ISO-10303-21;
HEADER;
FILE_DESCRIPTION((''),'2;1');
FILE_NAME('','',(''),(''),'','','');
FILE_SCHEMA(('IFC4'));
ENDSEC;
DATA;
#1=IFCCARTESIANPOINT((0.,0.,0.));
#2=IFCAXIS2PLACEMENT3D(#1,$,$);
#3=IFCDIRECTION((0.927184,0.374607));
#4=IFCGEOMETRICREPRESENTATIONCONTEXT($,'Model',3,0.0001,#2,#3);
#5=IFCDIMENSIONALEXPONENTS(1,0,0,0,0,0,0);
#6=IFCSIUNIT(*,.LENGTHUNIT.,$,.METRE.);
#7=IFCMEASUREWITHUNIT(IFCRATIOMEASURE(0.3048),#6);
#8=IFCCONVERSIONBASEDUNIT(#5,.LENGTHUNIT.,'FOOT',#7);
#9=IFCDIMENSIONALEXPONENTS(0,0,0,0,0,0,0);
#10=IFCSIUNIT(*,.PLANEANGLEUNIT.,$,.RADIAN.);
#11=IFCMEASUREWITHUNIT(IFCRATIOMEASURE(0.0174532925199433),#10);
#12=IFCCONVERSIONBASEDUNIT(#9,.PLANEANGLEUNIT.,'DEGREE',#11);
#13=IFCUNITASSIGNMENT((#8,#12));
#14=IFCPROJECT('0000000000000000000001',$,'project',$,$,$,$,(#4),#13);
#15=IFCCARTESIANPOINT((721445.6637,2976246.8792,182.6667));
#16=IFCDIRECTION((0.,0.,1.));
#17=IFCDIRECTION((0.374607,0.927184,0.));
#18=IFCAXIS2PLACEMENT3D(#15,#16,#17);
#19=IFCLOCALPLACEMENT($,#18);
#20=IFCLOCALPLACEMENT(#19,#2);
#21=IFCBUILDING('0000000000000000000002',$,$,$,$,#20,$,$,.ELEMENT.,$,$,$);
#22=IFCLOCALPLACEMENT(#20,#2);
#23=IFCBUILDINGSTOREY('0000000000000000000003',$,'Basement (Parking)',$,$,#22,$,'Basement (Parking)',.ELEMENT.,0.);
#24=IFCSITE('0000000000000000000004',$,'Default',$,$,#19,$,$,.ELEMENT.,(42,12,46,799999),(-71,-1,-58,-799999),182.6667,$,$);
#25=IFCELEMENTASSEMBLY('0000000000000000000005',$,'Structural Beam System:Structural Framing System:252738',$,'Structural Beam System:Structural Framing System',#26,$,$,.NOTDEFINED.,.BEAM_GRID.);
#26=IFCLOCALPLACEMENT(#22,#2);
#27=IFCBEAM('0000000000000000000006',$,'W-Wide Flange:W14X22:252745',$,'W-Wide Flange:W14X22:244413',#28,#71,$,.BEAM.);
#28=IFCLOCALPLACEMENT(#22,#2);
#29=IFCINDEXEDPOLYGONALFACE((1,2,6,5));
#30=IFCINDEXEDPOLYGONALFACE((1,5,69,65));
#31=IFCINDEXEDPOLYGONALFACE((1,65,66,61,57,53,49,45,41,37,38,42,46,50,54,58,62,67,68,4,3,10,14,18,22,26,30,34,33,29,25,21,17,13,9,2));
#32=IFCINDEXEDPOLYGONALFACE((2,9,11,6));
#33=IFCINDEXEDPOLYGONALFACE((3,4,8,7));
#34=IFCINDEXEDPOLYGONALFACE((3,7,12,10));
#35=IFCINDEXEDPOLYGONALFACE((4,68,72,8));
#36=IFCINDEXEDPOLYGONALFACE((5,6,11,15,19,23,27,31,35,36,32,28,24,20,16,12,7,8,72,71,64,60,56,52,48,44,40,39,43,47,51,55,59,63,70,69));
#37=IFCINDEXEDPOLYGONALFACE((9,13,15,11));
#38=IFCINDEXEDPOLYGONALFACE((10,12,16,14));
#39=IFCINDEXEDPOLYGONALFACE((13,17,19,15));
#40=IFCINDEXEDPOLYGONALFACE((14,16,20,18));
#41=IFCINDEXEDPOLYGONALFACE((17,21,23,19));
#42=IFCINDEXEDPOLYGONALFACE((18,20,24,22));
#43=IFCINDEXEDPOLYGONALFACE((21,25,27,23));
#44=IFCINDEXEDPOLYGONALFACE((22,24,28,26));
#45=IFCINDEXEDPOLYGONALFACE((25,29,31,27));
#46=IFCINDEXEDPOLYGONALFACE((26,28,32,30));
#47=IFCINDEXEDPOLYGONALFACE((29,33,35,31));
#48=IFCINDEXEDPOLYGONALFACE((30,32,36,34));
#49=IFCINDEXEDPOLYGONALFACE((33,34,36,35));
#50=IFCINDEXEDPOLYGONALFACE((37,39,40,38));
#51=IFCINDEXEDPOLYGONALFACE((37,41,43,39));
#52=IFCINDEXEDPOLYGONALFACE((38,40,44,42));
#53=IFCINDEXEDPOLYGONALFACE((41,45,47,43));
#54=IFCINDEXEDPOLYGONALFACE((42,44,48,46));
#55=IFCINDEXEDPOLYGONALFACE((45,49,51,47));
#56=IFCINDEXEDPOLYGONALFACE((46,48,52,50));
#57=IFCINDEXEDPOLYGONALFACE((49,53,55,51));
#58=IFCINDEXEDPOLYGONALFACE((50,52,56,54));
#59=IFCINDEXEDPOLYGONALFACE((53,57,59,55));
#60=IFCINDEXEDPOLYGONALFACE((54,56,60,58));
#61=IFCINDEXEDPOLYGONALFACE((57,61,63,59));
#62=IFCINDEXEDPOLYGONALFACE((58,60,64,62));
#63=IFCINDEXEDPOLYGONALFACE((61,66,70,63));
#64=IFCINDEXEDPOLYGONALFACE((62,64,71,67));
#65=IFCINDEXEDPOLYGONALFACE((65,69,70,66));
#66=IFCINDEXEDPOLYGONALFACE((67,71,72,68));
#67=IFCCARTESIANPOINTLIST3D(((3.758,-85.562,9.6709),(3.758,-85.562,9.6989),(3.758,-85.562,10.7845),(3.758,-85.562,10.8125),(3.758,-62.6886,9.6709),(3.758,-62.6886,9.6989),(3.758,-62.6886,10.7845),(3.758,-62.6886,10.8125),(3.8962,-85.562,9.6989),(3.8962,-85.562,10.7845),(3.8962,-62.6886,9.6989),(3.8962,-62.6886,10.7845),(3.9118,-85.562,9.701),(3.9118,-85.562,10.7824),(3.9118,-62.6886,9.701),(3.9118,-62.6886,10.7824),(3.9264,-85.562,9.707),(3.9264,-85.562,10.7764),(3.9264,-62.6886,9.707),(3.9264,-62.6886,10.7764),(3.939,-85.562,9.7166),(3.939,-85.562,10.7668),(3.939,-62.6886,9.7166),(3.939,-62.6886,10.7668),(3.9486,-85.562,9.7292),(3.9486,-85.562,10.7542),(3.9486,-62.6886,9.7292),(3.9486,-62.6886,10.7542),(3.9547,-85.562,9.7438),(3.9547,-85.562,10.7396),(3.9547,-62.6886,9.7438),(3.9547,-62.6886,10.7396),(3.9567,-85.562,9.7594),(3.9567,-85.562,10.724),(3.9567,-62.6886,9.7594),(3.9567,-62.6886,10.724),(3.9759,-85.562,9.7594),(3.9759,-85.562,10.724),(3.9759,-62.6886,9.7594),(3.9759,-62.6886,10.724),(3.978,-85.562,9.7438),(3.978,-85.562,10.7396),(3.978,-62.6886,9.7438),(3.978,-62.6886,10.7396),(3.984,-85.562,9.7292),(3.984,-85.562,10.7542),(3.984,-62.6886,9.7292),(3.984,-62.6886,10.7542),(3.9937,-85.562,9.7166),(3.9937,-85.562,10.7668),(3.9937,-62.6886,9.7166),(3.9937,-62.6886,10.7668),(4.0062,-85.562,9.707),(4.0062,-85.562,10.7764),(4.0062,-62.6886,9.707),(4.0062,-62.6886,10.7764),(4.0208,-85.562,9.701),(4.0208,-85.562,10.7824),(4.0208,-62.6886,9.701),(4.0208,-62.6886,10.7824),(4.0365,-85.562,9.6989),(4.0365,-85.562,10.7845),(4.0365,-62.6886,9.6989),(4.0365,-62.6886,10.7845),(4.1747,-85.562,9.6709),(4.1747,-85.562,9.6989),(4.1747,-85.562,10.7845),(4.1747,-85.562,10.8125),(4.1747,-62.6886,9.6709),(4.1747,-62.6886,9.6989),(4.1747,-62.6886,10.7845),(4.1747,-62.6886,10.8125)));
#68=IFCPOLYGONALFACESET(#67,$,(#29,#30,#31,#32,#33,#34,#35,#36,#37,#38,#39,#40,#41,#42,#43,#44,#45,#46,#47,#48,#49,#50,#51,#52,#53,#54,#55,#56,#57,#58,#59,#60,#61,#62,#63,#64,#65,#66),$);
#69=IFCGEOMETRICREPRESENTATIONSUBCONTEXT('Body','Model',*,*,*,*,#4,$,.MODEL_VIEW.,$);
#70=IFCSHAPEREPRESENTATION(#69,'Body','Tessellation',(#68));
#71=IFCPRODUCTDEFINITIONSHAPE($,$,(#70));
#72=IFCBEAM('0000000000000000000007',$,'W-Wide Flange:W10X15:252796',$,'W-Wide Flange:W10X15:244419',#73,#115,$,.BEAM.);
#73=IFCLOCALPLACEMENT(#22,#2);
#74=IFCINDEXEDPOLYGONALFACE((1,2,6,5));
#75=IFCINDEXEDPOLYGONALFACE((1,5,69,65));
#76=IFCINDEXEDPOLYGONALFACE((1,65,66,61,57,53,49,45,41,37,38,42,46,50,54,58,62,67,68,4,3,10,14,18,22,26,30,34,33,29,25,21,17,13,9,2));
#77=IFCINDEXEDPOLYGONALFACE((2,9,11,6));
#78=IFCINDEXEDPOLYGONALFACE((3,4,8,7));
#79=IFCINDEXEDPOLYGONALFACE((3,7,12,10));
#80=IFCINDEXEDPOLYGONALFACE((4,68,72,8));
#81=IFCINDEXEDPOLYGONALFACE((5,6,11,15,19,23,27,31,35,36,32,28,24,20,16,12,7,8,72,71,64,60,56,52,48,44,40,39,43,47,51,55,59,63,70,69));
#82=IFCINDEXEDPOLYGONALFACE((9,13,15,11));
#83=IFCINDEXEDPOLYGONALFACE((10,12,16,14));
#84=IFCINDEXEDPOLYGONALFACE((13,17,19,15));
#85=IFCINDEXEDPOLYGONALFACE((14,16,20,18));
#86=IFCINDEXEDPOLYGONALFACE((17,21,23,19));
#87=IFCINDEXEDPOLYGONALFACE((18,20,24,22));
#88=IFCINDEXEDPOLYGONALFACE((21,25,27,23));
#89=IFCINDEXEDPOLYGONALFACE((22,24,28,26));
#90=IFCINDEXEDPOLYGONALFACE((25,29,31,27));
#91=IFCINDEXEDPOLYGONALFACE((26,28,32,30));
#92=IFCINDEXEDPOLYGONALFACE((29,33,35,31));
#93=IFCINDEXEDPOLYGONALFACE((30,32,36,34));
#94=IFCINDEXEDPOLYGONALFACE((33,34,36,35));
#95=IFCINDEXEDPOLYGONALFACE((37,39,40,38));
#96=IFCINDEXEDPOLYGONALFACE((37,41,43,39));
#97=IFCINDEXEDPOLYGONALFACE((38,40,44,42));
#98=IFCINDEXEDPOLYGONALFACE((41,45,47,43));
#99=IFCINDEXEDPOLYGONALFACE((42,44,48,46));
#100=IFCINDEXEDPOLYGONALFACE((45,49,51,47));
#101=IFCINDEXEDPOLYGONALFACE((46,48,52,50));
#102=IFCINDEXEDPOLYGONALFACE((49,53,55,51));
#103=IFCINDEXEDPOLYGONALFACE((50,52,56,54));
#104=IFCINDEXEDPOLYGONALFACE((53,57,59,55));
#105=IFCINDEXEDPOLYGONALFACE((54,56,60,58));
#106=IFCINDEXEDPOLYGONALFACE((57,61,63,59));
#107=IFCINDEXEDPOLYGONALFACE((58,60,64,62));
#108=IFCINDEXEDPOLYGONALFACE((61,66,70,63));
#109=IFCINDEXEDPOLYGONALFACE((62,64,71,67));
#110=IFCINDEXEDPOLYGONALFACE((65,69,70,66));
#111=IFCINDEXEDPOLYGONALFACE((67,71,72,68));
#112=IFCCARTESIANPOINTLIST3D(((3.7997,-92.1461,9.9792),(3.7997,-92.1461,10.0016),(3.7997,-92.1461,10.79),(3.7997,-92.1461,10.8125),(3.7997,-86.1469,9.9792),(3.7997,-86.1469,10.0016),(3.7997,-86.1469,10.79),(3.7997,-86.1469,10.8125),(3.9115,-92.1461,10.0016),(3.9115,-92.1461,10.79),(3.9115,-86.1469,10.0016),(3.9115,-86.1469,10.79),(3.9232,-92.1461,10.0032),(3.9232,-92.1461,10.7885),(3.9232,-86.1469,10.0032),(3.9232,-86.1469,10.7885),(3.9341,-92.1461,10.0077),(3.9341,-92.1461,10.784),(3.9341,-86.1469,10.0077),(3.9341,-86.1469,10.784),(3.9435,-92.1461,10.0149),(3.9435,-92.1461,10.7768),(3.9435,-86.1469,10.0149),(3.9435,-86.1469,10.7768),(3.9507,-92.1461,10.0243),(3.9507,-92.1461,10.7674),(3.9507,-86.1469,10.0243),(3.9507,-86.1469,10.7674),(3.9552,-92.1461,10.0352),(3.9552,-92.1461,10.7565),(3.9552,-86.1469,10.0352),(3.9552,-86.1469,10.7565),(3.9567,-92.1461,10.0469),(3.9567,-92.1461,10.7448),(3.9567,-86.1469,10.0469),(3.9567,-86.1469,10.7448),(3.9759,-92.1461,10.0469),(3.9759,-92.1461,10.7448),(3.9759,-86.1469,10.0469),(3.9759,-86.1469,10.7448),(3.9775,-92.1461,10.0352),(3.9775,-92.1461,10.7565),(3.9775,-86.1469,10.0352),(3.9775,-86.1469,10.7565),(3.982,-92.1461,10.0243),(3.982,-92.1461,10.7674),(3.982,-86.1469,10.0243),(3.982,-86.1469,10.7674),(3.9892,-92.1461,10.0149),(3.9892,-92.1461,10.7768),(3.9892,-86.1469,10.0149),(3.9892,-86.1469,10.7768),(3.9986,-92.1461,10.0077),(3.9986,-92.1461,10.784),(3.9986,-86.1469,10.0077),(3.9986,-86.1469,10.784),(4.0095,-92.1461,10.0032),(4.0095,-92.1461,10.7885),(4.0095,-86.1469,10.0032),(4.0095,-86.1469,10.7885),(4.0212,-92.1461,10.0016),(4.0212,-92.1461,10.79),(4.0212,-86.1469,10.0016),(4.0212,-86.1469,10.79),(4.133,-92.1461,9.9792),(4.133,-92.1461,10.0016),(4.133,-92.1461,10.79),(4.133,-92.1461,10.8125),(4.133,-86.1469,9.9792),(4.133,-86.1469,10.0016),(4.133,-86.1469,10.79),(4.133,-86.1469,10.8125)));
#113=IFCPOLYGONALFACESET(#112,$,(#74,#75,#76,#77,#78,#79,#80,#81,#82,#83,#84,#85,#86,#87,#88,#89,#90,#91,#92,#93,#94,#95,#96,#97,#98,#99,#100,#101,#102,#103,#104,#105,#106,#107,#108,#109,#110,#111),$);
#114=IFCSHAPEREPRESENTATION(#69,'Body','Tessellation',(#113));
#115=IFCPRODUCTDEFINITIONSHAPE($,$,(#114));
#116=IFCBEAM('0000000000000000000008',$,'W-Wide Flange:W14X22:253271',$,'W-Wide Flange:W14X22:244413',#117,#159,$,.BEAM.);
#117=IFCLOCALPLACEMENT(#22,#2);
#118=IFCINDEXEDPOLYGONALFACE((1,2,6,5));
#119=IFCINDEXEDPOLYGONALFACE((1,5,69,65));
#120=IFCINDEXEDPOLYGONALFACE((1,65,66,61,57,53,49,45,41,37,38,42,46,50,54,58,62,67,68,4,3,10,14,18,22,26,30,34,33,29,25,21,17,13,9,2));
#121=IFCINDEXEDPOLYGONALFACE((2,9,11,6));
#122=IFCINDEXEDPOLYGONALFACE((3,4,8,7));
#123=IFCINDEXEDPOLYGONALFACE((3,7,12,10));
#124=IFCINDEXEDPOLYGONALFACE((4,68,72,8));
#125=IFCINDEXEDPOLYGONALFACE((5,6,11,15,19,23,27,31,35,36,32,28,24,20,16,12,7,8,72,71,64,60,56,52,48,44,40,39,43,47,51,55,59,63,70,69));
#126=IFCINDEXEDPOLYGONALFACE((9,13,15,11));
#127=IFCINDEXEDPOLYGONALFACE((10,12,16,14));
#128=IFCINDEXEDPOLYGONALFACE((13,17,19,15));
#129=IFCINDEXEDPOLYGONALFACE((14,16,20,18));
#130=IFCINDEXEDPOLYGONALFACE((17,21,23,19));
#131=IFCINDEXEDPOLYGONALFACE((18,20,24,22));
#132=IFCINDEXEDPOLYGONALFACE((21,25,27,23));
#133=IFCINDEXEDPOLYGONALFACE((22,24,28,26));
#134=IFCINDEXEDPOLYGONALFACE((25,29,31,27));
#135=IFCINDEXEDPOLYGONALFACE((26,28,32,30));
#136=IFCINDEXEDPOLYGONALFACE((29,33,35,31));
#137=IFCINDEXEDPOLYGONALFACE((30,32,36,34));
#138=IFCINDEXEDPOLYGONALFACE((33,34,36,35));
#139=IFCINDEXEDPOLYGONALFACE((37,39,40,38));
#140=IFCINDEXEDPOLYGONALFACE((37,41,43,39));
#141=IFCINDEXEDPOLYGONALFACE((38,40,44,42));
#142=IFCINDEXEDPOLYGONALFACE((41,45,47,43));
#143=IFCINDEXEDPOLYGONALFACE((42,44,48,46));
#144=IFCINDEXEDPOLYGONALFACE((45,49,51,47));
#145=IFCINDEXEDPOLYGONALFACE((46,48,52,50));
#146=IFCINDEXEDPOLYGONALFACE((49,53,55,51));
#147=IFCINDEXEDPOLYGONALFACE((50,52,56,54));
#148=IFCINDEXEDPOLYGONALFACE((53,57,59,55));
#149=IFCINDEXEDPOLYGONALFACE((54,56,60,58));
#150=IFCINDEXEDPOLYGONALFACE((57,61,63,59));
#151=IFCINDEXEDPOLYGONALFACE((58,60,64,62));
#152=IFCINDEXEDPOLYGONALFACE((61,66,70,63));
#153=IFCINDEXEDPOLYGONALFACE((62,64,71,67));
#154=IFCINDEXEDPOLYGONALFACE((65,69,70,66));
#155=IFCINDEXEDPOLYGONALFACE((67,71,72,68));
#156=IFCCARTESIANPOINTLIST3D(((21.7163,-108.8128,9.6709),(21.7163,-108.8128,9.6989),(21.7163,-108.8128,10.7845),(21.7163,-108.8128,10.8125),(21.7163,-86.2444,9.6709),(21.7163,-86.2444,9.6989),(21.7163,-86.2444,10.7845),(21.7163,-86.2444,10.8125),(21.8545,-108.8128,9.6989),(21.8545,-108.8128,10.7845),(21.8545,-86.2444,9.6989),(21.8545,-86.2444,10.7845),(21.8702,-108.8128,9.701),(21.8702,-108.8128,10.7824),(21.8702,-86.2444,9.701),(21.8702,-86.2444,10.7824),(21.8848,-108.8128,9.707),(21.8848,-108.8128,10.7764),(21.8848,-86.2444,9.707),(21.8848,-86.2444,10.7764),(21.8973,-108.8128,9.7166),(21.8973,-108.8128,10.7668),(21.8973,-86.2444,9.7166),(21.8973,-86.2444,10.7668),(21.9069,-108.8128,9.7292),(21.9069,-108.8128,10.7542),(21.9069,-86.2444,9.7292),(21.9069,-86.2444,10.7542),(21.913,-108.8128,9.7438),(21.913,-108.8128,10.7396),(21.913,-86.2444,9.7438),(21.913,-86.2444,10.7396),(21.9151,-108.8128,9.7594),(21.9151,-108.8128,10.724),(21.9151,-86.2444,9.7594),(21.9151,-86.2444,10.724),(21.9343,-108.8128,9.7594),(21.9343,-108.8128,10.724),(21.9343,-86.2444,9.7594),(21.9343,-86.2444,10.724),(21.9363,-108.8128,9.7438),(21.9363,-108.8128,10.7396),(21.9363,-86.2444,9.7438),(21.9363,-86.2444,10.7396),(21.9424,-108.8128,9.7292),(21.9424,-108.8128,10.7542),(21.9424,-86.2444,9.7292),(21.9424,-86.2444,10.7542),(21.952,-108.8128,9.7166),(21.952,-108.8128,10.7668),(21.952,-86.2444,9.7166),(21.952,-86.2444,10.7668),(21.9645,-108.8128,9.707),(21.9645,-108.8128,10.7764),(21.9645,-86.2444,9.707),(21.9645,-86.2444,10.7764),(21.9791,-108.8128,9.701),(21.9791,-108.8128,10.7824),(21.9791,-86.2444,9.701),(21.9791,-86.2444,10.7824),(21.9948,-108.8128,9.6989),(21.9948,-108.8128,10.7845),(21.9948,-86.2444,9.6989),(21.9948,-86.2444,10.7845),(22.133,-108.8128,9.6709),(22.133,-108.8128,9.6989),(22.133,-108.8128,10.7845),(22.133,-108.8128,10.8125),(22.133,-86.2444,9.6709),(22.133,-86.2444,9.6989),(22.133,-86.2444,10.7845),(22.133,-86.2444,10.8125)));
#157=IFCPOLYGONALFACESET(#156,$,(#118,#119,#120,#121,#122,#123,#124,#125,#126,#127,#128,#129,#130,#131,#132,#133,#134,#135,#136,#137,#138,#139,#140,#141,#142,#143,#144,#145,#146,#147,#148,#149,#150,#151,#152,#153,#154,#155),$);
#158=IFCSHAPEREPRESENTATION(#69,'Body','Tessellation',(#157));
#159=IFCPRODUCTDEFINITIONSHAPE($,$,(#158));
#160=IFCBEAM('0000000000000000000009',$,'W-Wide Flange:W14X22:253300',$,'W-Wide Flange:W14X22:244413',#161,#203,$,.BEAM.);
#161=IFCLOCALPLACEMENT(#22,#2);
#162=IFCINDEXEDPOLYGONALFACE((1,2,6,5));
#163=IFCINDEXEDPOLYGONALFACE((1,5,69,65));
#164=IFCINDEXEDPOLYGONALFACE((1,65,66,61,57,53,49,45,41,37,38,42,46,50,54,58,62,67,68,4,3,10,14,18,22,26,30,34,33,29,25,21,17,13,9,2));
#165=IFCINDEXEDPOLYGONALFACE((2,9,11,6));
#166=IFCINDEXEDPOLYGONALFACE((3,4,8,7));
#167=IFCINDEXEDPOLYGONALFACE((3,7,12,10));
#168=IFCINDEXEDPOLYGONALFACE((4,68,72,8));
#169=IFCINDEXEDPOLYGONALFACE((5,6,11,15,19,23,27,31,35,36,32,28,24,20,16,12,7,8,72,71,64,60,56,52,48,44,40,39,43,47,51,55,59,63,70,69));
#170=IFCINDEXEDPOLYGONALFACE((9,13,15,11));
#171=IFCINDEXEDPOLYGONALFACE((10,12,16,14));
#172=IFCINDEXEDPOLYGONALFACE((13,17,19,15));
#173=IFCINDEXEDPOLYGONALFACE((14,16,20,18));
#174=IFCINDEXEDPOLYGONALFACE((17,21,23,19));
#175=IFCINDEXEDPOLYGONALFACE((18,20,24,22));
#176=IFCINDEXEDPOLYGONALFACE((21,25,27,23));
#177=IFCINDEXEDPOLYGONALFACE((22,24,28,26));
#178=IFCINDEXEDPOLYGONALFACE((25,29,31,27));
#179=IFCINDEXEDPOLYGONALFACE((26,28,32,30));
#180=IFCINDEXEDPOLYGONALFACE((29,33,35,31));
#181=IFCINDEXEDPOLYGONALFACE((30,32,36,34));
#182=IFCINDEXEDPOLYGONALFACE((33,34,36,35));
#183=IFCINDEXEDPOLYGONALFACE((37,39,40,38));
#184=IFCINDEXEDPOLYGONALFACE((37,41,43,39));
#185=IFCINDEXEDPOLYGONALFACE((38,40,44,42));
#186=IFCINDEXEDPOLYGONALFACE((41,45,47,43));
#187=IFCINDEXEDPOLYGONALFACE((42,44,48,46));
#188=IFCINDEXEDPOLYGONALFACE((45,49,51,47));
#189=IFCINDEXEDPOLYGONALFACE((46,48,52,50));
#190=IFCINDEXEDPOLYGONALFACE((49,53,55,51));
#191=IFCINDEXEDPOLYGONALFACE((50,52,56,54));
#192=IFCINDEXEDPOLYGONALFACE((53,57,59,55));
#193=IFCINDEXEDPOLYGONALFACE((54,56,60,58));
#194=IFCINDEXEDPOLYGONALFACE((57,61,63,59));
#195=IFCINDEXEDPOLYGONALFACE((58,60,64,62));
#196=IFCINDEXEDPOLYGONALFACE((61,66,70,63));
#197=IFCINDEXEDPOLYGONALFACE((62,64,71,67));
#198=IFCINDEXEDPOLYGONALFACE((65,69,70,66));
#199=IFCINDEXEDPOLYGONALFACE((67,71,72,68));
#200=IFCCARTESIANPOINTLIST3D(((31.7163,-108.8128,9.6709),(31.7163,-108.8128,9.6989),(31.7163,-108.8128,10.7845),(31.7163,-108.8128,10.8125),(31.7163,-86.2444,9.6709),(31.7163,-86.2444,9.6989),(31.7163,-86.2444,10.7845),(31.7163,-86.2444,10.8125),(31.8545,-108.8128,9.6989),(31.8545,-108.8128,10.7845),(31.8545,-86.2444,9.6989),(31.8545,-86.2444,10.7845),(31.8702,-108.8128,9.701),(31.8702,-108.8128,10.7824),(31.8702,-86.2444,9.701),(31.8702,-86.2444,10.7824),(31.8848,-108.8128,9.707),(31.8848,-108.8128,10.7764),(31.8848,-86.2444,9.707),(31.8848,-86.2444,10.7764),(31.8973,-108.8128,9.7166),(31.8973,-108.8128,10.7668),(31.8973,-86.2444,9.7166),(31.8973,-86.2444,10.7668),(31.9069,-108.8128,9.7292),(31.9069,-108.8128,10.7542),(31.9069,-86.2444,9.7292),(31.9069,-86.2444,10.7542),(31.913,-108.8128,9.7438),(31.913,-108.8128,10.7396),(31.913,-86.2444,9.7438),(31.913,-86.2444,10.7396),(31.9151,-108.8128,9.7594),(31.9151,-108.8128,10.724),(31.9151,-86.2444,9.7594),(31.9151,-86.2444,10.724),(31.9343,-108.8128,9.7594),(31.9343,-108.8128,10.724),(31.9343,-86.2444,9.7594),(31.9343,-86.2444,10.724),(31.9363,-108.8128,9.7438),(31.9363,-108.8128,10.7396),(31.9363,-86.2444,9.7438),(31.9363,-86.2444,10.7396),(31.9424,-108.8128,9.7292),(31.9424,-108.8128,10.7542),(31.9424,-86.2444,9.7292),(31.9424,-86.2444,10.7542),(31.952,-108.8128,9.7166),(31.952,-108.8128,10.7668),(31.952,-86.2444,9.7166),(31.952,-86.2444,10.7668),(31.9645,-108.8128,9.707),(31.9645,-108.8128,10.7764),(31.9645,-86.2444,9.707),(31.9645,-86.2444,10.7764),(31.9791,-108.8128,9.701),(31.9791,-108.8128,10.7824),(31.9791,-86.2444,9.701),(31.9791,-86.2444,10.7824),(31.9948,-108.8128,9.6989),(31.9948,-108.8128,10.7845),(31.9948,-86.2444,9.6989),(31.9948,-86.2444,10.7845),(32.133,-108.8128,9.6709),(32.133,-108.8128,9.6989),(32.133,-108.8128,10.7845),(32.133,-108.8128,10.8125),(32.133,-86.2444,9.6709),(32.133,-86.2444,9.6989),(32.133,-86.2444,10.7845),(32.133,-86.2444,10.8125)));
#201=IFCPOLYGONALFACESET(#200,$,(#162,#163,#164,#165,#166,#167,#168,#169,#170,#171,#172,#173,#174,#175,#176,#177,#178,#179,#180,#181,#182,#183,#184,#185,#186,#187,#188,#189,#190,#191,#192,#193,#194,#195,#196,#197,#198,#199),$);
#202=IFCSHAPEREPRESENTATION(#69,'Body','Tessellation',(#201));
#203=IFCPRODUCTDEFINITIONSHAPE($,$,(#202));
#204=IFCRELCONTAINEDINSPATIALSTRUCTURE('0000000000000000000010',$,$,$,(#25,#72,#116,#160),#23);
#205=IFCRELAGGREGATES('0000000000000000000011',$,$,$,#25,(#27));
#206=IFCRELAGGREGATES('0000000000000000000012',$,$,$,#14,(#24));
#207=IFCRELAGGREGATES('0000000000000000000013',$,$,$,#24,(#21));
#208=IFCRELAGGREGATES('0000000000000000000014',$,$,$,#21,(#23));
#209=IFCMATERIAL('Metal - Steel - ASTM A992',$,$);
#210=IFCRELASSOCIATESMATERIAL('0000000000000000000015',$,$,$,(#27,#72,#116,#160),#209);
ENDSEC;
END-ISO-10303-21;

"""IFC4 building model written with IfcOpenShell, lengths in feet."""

from ifc_helpers import new_model, entity, si_unit, converted_unit, direction, frame, frame_2d, origin, place, context, subcontext, project, spatial, i_section, extrude, material, element, aggregate, save


model = new_model("IFC4")

# Units and contexts
model_context = context("Model", 3, precision=0.0001, world=origin(), true_north=direction((0.927184, 0.374607)))
body_context = subcontext(model_context, "Body", "Model", "MODEL_VIEW")
ifc_project = project(units=[converted_unit("LENGTHUNIT", "FOOT", entity("IfcRatioMeasure", 0.3048), si_unit("LENGTHUNIT", "METRE"), dimensions=[1, 0, 0, 0, 0, 0, 0]), converted_unit("PLANEANGLEUNIT", "DEGREE", entity("IfcRatioMeasure", 0.0174532925199433), si_unit("PLANEANGLEUNIT", "RADIAN"), dimensions=[0, 0, 0, 0, 0, 0, 0])], contexts=[model_context])

# Site, building, storey
site_placement = place(None, frame((721445.6637, 2976246.8792, 182.6667), z_axis=(0.0, 0.0, 1.0), x_axis=(0.374607, 0.927184, 0.0)))
site = spatial("IfcSite", under=ifc_project, at=site_placement, Name="Default", CompositionType="ELEMENT", RefLatitude=(42, 12, 46, 799999), RefLongitude=(-71, -1, -58, -799999), RefElevation=182.6667)
building_placement = place(site_placement, origin())
building = spatial("IfcBuilding", under=site, at=building_placement, CompositionType="ELEMENT")
storey_placement = place(building_placement, origin())
storey = spatial("IfcBuildingStorey", under=building, at=storey_placement, Name="Basement (Parking)", LongName="Basement (Parking)", CompositionType="ELEMENT", Elevation=0.0)

# Shared definitions
ifc_material_1 = material(Name="Metal - Steel - ASTM A992")

# Element assembly, beam
assembly_placement = place(storey_placement, origin())
assembly = element("IfcElementAssembly", 1, at=assembly_placement, inside=storey, Name="Structural Beam System:Structural Framing System:252738", ObjectType="Structural Beam System:Structural Framing System", AssemblyPlace="NOTDEFINED", PredefinedType="BEAM_GRID")
beam_1_placement = place(assembly_placement, frame((3.9663, -85.8544, 10.8125), z_axis=(0.0, 0.0, 1.0), x_axis=(0.0, 1.0, 0.0)))
beam_1 = element("IfcBeam", 2, at=beam_1_placement, material=ifc_material_1, Name="W-Wide Flange:W14X22:252745", ObjectType="W-Wide Flange:W14X22:244413", PredefinedType="BEAM", context=body_context, shape_type="SweptSolid", body=[
    extrude(i_section(OverallWidth=0.4167, OverallDepth=1.1416, WebThickness=0.0192, FlangeThickness=0.028, FilletRadius=0.0605, at=frame_2d((0.0, 0.0), x_axis=(0.0, 1.0))), frame((0.2925, 0.0, -0.5708), z_axis=(1.0, 0.0, 0.0), x_axis=(0.0, 0.0, -1.0)), (0.0, 0.0, 1.0), 22.8734),
])
aggregate(assembly, [beam_1])

# Beams
beam_2_placement = place(storey_placement, frame((3.9663, -85.8544, 10.8125), z_axis=(0.0, 0.0, 1.0), x_axis=(0.0, -1.0, 0.0)))
element("IfcBeam", 3, at=beam_2_placement, inside=storey, material=ifc_material_1, Name="W-Wide Flange:W10X15:252796", ObjectType="W-Wide Flange:W10X15:244419", PredefinedType="BEAM", context=body_context, shape_type="SweptSolid", body=[
    extrude(i_section(OverallWidth=0.3333, OverallDepth=0.8333, WebThickness=0.0192, FlangeThickness=0.0225, FilletRadius=0.0452, at=frame_2d((0.0, 0.0), x_axis=(0.0, 1.0))), frame((0.2925, 0.0, -0.4167), z_axis=(1.0, 0.0, 0.0), x_axis=(0.0, 0.0, -1.0)), (0.0, 0.0, 1.0), 5.9992),
])
beam_3_placement = place(storey_placement, frame((21.9247, -85.8544, 10.8125), z_axis=(0.0, 0.0, 1.0), x_axis=(0.0, -1.0, 0.0)))
element("IfcBeam", 4, at=beam_3_placement, inside=storey, material=ifc_material_1, Name="W-Wide Flange:W14X22:253271", ObjectType="W-Wide Flange:W14X22:244413", PredefinedType="BEAM", context=body_context, shape_type="SweptSolid", body=[
    extrude(i_section(OverallWidth=0.4167, OverallDepth=1.1416, WebThickness=0.0192, FlangeThickness=0.028, FilletRadius=0.0605, at=frame_2d((0.0, 0.0), x_axis=(0.0, 1.0))), frame((0.39, 0.0, -0.5708), z_axis=(1.0, 0.0, 0.0), x_axis=(0.0, 0.0, -1.0)), (0.0, 0.0, 1.0), 22.5684),
])
beam_4_placement = place(storey_placement, frame((31.9247, -85.8544, 10.8125), z_axis=(0.0, 0.0, 1.0), x_axis=(0.0, -1.0, 0.0)))
element("IfcBeam", 5, at=beam_4_placement, inside=storey, material=ifc_material_1, Name="W-Wide Flange:W14X22:253300", ObjectType="W-Wide Flange:W14X22:244413", PredefinedType="BEAM", context=body_context, shape_type="SweptSolid", body=[
    extrude(i_section(OverallWidth=0.4167, OverallDepth=1.1416, WebThickness=0.0192, FlangeThickness=0.028, FilletRadius=0.0605, at=frame_2d((0.0, 0.0), x_axis=(0.0, 1.0))), frame((0.39, 0.0, -0.5708), z_axis=(1.0, 0.0, 0.0), x_axis=(0.0, 0.0, -1.0)), (0.0, 0.0, 1.0), 22.5684),
])

save(model, "model.ifc")
